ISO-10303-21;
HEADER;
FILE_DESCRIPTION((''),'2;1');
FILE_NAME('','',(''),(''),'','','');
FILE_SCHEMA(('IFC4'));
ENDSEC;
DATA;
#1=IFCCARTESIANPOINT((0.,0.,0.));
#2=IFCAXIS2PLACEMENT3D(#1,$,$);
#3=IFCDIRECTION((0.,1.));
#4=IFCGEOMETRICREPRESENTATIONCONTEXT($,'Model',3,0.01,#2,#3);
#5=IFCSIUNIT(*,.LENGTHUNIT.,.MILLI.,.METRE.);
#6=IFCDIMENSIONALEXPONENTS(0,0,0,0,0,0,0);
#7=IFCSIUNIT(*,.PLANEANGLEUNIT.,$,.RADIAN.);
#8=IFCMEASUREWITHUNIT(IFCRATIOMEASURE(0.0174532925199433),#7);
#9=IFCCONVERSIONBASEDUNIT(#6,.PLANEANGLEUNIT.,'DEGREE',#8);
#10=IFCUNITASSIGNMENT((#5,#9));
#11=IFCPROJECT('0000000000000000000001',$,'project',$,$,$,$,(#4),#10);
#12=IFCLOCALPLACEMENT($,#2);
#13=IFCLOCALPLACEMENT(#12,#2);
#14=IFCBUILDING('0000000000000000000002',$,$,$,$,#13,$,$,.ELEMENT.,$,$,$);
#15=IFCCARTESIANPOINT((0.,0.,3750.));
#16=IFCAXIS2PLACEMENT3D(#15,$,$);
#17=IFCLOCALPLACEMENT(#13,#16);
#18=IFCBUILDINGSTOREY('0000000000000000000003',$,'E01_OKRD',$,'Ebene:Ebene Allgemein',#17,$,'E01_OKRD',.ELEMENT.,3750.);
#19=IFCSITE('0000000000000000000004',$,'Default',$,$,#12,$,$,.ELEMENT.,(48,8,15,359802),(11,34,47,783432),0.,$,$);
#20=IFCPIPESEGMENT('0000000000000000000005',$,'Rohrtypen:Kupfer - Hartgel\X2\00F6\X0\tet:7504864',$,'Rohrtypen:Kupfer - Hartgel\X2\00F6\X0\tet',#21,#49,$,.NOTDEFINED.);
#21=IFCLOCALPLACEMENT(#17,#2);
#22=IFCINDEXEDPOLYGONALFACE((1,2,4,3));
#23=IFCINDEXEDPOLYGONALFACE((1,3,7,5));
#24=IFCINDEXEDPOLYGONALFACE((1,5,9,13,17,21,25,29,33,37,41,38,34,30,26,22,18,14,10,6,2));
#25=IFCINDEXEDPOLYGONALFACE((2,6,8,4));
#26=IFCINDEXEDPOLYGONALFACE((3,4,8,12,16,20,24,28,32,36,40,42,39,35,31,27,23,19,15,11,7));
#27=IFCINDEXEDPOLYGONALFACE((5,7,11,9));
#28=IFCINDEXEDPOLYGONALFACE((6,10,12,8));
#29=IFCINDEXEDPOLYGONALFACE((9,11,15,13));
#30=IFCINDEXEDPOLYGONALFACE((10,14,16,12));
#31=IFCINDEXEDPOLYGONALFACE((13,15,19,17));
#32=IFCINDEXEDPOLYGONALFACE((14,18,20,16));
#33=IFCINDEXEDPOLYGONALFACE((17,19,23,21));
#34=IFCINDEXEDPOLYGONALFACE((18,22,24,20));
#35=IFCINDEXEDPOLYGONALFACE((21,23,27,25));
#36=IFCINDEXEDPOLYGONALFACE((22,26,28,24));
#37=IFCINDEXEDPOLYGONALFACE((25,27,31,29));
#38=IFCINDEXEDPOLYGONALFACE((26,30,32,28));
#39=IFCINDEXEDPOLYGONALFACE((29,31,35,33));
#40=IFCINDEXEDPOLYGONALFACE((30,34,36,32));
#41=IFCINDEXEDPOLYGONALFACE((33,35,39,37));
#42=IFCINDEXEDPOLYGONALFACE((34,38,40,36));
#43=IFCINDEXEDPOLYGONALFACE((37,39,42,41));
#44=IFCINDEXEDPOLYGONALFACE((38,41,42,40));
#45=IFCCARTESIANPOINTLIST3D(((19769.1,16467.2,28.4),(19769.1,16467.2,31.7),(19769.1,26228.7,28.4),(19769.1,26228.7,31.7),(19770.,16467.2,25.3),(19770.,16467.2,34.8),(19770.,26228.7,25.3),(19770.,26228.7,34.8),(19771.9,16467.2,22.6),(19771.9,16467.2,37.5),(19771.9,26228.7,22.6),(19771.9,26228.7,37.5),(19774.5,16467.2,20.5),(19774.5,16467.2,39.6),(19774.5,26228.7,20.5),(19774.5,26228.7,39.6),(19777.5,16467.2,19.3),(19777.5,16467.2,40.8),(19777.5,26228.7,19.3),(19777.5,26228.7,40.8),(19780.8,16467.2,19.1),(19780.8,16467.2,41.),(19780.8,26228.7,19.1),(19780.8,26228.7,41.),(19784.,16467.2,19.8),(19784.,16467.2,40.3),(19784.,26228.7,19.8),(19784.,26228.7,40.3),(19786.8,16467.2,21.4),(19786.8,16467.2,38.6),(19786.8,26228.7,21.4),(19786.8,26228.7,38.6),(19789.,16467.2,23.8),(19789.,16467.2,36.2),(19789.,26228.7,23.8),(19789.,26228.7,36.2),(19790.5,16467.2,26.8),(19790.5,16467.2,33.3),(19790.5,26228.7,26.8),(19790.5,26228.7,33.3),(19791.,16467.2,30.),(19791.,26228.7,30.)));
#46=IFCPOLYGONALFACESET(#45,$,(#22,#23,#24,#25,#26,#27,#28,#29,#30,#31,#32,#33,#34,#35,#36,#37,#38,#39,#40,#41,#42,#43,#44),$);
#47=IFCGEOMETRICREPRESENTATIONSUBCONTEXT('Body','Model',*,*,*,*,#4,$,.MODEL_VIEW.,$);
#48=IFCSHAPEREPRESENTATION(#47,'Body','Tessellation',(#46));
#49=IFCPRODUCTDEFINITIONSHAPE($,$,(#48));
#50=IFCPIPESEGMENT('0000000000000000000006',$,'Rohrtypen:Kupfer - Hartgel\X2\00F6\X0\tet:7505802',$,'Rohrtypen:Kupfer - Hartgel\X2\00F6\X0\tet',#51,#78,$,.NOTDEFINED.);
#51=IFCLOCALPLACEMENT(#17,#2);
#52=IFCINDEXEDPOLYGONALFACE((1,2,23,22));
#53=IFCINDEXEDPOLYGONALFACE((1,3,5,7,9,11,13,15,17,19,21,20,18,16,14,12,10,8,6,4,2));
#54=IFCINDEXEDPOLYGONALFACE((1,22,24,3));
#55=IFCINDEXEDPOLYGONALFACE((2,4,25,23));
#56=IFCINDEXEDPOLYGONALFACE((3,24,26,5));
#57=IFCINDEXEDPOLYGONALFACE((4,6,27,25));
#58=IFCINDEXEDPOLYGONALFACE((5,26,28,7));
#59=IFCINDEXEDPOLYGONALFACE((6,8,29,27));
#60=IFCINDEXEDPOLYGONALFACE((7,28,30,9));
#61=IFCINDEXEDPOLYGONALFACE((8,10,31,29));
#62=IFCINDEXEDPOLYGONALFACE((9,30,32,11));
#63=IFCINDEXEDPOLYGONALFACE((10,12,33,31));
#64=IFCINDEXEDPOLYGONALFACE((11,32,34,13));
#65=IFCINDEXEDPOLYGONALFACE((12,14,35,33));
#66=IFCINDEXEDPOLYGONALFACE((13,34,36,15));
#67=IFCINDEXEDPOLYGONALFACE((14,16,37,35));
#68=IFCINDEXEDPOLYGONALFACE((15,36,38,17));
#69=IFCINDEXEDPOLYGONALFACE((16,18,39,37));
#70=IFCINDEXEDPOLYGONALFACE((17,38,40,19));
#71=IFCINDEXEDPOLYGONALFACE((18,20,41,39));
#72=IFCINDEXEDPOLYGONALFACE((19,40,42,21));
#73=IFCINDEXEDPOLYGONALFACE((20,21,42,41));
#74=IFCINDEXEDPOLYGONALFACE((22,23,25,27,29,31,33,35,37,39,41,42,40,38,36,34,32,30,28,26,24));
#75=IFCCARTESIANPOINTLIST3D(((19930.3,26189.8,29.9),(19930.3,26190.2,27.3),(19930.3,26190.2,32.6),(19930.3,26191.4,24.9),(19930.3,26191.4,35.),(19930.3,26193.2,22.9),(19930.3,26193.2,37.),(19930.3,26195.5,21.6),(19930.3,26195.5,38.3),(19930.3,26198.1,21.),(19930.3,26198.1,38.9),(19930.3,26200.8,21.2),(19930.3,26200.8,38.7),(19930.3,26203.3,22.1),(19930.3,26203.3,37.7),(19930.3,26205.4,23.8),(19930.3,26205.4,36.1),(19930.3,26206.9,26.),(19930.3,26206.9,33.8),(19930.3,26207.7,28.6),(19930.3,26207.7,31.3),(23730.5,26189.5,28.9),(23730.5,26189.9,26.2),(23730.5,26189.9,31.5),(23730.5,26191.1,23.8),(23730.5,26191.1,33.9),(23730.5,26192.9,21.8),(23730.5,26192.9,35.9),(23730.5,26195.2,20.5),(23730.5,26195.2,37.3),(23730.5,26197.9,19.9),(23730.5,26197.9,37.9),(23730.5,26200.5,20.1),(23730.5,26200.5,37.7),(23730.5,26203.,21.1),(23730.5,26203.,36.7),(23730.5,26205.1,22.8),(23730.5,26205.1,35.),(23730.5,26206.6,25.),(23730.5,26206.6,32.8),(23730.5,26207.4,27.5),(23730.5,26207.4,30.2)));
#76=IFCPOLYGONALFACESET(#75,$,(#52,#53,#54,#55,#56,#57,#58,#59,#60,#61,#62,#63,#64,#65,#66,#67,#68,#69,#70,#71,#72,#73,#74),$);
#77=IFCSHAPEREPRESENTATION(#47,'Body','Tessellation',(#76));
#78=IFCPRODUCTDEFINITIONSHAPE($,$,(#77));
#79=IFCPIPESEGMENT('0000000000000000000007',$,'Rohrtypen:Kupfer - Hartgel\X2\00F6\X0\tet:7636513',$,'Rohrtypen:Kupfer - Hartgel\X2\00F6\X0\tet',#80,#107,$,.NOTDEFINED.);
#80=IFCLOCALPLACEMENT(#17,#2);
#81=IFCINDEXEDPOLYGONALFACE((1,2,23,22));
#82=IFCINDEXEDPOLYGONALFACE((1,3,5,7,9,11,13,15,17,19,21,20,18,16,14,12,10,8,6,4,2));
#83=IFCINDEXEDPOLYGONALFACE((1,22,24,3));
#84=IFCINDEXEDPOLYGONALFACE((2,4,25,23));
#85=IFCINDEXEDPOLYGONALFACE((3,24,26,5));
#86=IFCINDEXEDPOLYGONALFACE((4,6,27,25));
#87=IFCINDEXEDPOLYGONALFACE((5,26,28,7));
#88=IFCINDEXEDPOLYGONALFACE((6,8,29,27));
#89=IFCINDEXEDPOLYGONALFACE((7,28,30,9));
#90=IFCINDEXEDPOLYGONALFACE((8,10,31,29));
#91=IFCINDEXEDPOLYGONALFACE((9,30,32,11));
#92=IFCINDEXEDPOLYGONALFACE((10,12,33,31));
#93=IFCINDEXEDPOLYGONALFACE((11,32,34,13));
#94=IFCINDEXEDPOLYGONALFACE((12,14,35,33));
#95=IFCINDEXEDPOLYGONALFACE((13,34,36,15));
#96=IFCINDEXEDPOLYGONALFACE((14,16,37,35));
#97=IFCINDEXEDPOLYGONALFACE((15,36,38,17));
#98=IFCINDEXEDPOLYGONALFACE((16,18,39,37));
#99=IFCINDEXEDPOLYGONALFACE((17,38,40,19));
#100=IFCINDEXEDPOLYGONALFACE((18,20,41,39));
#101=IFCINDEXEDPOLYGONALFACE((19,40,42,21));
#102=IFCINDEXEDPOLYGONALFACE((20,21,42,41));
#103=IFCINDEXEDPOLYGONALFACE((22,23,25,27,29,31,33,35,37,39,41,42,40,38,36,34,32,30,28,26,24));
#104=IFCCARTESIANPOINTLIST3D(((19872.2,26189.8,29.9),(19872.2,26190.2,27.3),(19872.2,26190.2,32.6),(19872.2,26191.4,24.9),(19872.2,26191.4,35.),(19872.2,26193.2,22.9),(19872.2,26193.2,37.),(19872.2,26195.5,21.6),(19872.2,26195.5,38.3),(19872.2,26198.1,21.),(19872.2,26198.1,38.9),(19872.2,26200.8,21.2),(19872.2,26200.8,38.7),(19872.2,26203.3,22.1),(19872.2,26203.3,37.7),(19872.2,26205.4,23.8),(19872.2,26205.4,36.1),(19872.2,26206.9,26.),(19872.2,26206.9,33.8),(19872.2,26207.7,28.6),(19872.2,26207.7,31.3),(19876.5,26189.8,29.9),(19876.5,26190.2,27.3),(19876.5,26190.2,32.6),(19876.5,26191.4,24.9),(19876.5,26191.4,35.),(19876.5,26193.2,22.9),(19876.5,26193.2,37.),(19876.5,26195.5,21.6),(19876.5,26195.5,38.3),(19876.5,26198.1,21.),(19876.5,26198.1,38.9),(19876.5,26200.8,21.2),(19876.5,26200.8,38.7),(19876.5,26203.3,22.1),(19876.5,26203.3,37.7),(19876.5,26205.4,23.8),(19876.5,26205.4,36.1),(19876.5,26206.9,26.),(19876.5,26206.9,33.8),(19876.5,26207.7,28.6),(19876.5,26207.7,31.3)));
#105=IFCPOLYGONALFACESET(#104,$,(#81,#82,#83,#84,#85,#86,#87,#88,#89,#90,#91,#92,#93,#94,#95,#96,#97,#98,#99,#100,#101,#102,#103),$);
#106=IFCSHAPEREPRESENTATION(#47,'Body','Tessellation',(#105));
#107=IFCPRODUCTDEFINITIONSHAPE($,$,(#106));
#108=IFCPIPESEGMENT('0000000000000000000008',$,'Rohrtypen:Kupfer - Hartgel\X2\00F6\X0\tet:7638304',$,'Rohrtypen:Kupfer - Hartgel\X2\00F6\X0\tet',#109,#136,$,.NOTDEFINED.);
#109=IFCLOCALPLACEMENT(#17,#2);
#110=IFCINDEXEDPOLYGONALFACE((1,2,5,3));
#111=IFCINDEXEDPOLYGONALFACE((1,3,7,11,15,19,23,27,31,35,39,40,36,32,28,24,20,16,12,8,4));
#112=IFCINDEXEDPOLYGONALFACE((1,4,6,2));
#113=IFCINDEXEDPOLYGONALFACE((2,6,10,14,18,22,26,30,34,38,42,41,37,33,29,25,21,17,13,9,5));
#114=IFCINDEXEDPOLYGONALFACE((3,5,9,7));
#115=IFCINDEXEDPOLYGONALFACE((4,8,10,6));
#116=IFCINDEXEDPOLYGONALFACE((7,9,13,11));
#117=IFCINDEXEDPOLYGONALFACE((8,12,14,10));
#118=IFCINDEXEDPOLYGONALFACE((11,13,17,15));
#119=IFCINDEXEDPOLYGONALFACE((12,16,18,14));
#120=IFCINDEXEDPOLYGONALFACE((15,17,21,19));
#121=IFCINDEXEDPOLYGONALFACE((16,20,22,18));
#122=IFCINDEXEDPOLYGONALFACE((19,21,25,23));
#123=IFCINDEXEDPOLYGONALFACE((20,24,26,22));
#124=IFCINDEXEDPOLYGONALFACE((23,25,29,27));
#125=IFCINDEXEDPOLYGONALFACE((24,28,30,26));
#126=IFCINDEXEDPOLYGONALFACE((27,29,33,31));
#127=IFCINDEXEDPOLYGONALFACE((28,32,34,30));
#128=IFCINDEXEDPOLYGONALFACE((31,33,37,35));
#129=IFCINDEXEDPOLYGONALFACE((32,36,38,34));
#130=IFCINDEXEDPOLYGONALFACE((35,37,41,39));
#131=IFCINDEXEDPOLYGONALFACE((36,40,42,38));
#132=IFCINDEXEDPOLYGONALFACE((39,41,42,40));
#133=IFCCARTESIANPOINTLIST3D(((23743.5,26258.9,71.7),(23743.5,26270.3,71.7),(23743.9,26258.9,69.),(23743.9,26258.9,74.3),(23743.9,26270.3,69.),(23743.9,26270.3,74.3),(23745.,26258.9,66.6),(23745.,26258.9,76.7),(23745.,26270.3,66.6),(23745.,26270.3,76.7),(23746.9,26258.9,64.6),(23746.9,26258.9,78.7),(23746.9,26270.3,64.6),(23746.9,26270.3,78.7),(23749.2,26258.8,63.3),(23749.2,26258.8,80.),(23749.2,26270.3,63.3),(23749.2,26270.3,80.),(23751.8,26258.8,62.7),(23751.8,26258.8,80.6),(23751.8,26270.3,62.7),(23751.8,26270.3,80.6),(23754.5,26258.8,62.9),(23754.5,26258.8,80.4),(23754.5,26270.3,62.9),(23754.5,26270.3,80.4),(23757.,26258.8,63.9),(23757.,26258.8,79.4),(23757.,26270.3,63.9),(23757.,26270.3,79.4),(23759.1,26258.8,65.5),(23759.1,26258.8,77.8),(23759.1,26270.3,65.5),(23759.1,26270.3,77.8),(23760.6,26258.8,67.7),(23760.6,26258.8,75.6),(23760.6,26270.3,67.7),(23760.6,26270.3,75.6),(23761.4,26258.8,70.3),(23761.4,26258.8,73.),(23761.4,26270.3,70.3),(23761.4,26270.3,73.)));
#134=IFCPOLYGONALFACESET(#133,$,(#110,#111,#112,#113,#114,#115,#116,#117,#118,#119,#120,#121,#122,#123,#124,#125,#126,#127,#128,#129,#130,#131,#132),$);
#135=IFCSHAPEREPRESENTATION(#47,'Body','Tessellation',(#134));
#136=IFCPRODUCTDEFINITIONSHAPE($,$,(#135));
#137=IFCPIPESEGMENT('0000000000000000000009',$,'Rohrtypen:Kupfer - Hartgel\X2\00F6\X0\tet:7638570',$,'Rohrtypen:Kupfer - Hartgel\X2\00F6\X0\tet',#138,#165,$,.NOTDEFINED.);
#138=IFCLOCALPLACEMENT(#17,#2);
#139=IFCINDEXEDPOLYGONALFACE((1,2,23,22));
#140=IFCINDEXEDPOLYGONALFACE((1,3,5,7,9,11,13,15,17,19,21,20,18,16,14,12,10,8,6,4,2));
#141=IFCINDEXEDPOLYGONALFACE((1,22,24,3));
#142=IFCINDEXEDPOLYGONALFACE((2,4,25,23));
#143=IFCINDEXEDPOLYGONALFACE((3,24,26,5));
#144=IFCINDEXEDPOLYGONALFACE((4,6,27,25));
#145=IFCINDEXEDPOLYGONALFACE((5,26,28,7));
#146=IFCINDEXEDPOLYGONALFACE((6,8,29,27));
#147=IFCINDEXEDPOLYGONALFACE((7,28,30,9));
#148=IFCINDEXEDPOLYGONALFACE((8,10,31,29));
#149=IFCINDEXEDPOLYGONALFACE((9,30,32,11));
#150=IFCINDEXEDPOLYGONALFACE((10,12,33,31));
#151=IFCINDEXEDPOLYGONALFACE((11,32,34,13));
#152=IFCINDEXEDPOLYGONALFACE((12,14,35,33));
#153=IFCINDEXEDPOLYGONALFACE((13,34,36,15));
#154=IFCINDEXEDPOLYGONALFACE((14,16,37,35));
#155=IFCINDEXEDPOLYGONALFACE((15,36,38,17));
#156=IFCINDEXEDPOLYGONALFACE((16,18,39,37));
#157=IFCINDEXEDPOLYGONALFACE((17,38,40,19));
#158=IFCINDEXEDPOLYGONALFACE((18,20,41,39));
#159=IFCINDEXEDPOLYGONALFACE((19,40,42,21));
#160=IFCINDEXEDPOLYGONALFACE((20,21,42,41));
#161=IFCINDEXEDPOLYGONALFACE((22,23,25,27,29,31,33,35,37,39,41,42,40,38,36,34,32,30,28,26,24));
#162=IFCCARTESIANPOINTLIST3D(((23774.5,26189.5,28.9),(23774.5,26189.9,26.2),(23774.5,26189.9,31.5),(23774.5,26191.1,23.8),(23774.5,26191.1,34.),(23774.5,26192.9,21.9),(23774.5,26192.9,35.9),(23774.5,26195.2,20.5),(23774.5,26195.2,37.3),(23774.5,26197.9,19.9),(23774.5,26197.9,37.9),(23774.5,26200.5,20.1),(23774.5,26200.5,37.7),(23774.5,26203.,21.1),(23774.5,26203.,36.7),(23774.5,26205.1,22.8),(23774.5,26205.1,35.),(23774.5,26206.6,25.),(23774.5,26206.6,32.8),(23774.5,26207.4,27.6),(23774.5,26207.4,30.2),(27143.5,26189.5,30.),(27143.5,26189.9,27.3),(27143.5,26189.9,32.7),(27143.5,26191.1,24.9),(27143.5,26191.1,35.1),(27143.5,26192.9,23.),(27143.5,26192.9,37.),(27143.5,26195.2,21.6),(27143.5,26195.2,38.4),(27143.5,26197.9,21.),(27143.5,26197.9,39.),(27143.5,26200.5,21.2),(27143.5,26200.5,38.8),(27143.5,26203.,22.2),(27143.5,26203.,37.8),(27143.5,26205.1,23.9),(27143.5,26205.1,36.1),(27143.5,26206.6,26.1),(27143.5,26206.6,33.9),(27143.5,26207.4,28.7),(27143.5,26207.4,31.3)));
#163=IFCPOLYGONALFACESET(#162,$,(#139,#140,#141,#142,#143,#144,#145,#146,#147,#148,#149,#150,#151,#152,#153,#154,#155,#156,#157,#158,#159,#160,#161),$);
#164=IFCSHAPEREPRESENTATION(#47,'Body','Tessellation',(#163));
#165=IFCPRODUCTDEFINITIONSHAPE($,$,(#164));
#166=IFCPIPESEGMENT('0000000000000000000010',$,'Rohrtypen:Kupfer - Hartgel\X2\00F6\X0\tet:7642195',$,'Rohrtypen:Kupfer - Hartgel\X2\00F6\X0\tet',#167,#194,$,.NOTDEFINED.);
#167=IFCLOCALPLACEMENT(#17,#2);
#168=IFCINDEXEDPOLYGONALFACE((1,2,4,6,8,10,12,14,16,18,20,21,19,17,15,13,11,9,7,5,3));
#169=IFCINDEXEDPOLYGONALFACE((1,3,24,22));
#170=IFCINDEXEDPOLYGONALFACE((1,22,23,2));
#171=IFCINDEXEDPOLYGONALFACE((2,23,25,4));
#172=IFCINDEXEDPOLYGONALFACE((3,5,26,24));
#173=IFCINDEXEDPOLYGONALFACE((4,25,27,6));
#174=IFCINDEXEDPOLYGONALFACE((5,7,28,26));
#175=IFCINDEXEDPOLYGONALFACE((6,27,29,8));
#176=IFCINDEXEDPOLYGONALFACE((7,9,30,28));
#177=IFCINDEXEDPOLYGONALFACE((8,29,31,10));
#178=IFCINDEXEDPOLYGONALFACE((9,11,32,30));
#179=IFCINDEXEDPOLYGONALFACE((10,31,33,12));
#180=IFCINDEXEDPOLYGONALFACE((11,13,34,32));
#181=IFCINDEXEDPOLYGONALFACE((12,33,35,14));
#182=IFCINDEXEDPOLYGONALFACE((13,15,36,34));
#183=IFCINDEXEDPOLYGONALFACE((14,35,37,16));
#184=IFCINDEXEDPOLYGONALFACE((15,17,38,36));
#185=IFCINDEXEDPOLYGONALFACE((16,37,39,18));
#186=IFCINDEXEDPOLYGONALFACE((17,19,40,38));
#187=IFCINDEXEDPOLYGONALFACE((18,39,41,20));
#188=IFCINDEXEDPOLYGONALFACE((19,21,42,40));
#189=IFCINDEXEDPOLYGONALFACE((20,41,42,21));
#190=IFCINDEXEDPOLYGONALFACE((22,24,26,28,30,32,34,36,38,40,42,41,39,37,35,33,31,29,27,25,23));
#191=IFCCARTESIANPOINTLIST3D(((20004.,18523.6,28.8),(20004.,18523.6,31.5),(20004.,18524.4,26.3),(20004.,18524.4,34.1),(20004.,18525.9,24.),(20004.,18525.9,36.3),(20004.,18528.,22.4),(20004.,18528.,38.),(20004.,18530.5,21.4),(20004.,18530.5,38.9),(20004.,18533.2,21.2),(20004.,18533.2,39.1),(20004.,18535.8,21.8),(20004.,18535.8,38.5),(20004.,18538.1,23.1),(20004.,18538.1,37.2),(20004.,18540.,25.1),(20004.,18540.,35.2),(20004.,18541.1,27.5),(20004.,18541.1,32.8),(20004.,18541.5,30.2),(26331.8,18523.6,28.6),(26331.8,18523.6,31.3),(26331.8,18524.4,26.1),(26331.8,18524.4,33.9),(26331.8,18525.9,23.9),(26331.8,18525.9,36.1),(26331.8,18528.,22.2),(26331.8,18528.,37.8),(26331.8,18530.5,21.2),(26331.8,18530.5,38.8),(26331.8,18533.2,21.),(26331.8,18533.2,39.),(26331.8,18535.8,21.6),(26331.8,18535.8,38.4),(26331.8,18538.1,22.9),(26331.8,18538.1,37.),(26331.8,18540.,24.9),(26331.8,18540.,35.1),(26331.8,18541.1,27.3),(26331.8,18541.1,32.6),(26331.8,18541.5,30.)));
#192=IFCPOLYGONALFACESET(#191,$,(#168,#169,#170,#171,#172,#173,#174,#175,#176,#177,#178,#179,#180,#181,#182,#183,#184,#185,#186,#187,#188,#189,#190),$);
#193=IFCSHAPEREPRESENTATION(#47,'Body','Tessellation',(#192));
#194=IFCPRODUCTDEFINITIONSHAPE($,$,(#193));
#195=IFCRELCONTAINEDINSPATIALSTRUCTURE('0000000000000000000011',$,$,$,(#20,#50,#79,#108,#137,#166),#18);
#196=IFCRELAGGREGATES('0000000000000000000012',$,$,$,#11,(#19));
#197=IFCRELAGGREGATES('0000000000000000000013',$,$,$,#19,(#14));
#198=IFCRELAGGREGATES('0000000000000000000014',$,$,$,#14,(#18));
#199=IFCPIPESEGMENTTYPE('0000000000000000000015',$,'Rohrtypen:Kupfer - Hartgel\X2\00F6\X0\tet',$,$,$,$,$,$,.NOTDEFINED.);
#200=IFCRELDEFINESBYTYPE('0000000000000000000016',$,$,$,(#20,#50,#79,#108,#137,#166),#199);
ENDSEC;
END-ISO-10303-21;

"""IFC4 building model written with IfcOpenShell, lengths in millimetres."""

from ifc_helpers import new_model, entity, si_unit, converted_unit, direction, frame, origin, origin_2d_with_axis, place, context, subcontext, project, spatial, circle, extrude, type_object, element, save


model = new_model("IFC4")

# Units and contexts
model_context = context("Model", 3, precision=0.01, world=origin(), true_north=direction((0.0, 1.0)))
body_context = subcontext(model_context, "Body", "Model", "MODEL_VIEW")
ifc_project = project(units=[si_unit("LENGTHUNIT", "METRE", prefix="MILLI"), converted_unit("PLANEANGLEUNIT", "DEGREE", entity("IfcRatioMeasure", 0.0174532925199433), si_unit("PLANEANGLEUNIT", "RADIAN"), dimensions=[0, 0, 0, 0, 0, 0, 0])], contexts=[model_context])

# Site, building, storey
site_placement = place(None, origin())
site = spatial("IfcSite", under=ifc_project, at=site_placement, Name="Default", CompositionType="ELEMENT", RefLatitude=(48, 8, 15, 359802), RefLongitude=(11, 34, 47, 783432), RefElevation=0.0)
building_placement = place(site_placement, origin())
building = spatial("IfcBuilding", under=site, at=building_placement, CompositionType="ELEMENT")
storey_placement = place(building_placement, frame((0.0, 0.0, 3750.0)))
storey = spatial("IfcBuildingStorey", under=building, at=storey_placement, Name="E01_OKRD", ObjectType="Ebene:Ebene Allgemein", LongName="E01_OKRD", CompositionType="ELEMENT", Elevation=3750.0)

# Pipe segments
pipe_segment_type = type_object("IfcPipeSegmentType", Name="Rohrtypen:Kupfer - Hartgelötet", PredefinedType="NOTDEFINED")
pipe_segment_1_placement = place(storey_placement, frame((19767.4, 16467.2, 17.4)))
element("IfcPipeSegment", 1, at=pipe_segment_1_placement, inside=storey, type_object=pipe_segment_type, Name="Rohrtypen:Kupfer - Hartgelötet:7504864", ObjectType="Rohrtypen:Kupfer - Hartgelötet", PredefinedType="NOTDEFINED", context=body_context, shape_type="SweptSolid", body=[
    extrude(circle(Radius=11.0, at=origin_2d_with_axis()), frame((12.6, 0.0, 12.6), z_axis=(0.0, 1.0, 0.0), x_axis=(1.0, 0.0, 0.0)), (0.0, 0.0, 1.0), 9761.6),
])
pipe_segment_2_placement = place(storey_placement, frame((19930.3, 26187.9, 18.3)))
element("IfcPipeSegment", 2, at=pipe_segment_2_placement, inside=storey, type_object=pipe_segment_type, Name="Rohrtypen:Kupfer - Hartgelötet:7505802", ObjectType="Rohrtypen:Kupfer - Hartgelötet", PredefinedType="NOTDEFINED", context=body_context, shape_type="SweptSolid", body=[
    extrude(circle(Radius=9.0, at=origin_2d_with_axis()), frame((3800.2, 10.6, 10.6), z_axis=(-1.0, 0.000074, 0.000277), x_axis=(-0.000074, -1.0, 0.0)), (0.0, 0.0, 1.0), 3800.2),
])
pipe_segment_3_placement = place(storey_placement, frame((19872.2, 26188.2, 19.3)))
element("IfcPipeSegment", 3, at=pipe_segment_3_placement, inside=storey, type_object=pipe_segment_type, Name="Rohrtypen:Kupfer - Hartgelötet:7636513", ObjectType="Rohrtypen:Kupfer - Hartgelötet", PredefinedType="NOTDEFINED", context=body_context, shape_type="SweptSolid", body=[
    extrude(circle(Radius=9.0, at=origin_2d_with_axis()), frame((0.0, 10.6, 10.6), z_axis=(1.0, -0.0003, 0.0), x_axis=(-0.0003, -1.0, 0.0)), (0.0, 0.0, 1.0), 4.3),
])
pipe_segment_4_placement = place(storey_placement, frame((23741.9, 26258.8, 61.1)))
element("IfcPipeSegment", 4, at=pipe_segment_4_placement, inside=storey, type_object=pipe_segment_type, Name="Rohrtypen:Kupfer - Hartgelötet:7638304", ObjectType="Rohrtypen:Kupfer - Hartgelötet", PredefinedType="NOTDEFINED", context=body_context, shape_type="SweptSolid", body=[
    extrude(circle(Radius=9.0, at=origin_2d_with_axis()), frame((10.6, 0.0, 10.6), z_axis=(0.000455, 1.0, 0.0), x_axis=(-1.0, 0.000455, 0.0)), (0.0, 0.0, 1.0), 11.4),
])
pipe_segment_5_placement = place(storey_placement, frame((23774.5, 26187.9, 18.3)))
element("IfcPipeSegment", 5, at=pipe_segment_5_placement, inside=storey, type_object=pipe_segment_type, Name="Rohrtypen:Kupfer - Hartgelötet:7638570", ObjectType="Rohrtypen:Kupfer - Hartgelötet", PredefinedType="NOTDEFINED", context=body_context, shape_type="SweptSolid", body=[
    extrude(circle(Radius=9.0, at=origin_2d_with_axis()), frame((0.0, 10.6, 10.6), z_axis=(1.0, 0.0, 0.000329), x_axis=(0.0, -1.0, 0.0)), (0.0, 0.0, 1.0), 3369.0),
])
pipe_segment_6_placement = place(storey_placement, frame((20004.0, 18521.9, 19.4)))
element("IfcPipeSegment", 6, at=pipe_segment_6_placement, inside=storey, type_object=pipe_segment_type, Name="Rohrtypen:Kupfer - Hartgelötet:7642195", ObjectType="Rohrtypen:Kupfer - Hartgelötet", PredefinedType="NOTDEFINED", context=body_context, shape_type="SweptSolid", body=[
    extrude(circle(Radius=9.0, at=origin_2d_with_axis()), frame((0.0, 10.6, 10.8), z_axis=(1.0, 0.0, -0.000029), x_axis=(0.0, 1.0, 0.0)), (0.0, 0.0, 1.0), 6327.9),
])

save(model, "model.ifc")
